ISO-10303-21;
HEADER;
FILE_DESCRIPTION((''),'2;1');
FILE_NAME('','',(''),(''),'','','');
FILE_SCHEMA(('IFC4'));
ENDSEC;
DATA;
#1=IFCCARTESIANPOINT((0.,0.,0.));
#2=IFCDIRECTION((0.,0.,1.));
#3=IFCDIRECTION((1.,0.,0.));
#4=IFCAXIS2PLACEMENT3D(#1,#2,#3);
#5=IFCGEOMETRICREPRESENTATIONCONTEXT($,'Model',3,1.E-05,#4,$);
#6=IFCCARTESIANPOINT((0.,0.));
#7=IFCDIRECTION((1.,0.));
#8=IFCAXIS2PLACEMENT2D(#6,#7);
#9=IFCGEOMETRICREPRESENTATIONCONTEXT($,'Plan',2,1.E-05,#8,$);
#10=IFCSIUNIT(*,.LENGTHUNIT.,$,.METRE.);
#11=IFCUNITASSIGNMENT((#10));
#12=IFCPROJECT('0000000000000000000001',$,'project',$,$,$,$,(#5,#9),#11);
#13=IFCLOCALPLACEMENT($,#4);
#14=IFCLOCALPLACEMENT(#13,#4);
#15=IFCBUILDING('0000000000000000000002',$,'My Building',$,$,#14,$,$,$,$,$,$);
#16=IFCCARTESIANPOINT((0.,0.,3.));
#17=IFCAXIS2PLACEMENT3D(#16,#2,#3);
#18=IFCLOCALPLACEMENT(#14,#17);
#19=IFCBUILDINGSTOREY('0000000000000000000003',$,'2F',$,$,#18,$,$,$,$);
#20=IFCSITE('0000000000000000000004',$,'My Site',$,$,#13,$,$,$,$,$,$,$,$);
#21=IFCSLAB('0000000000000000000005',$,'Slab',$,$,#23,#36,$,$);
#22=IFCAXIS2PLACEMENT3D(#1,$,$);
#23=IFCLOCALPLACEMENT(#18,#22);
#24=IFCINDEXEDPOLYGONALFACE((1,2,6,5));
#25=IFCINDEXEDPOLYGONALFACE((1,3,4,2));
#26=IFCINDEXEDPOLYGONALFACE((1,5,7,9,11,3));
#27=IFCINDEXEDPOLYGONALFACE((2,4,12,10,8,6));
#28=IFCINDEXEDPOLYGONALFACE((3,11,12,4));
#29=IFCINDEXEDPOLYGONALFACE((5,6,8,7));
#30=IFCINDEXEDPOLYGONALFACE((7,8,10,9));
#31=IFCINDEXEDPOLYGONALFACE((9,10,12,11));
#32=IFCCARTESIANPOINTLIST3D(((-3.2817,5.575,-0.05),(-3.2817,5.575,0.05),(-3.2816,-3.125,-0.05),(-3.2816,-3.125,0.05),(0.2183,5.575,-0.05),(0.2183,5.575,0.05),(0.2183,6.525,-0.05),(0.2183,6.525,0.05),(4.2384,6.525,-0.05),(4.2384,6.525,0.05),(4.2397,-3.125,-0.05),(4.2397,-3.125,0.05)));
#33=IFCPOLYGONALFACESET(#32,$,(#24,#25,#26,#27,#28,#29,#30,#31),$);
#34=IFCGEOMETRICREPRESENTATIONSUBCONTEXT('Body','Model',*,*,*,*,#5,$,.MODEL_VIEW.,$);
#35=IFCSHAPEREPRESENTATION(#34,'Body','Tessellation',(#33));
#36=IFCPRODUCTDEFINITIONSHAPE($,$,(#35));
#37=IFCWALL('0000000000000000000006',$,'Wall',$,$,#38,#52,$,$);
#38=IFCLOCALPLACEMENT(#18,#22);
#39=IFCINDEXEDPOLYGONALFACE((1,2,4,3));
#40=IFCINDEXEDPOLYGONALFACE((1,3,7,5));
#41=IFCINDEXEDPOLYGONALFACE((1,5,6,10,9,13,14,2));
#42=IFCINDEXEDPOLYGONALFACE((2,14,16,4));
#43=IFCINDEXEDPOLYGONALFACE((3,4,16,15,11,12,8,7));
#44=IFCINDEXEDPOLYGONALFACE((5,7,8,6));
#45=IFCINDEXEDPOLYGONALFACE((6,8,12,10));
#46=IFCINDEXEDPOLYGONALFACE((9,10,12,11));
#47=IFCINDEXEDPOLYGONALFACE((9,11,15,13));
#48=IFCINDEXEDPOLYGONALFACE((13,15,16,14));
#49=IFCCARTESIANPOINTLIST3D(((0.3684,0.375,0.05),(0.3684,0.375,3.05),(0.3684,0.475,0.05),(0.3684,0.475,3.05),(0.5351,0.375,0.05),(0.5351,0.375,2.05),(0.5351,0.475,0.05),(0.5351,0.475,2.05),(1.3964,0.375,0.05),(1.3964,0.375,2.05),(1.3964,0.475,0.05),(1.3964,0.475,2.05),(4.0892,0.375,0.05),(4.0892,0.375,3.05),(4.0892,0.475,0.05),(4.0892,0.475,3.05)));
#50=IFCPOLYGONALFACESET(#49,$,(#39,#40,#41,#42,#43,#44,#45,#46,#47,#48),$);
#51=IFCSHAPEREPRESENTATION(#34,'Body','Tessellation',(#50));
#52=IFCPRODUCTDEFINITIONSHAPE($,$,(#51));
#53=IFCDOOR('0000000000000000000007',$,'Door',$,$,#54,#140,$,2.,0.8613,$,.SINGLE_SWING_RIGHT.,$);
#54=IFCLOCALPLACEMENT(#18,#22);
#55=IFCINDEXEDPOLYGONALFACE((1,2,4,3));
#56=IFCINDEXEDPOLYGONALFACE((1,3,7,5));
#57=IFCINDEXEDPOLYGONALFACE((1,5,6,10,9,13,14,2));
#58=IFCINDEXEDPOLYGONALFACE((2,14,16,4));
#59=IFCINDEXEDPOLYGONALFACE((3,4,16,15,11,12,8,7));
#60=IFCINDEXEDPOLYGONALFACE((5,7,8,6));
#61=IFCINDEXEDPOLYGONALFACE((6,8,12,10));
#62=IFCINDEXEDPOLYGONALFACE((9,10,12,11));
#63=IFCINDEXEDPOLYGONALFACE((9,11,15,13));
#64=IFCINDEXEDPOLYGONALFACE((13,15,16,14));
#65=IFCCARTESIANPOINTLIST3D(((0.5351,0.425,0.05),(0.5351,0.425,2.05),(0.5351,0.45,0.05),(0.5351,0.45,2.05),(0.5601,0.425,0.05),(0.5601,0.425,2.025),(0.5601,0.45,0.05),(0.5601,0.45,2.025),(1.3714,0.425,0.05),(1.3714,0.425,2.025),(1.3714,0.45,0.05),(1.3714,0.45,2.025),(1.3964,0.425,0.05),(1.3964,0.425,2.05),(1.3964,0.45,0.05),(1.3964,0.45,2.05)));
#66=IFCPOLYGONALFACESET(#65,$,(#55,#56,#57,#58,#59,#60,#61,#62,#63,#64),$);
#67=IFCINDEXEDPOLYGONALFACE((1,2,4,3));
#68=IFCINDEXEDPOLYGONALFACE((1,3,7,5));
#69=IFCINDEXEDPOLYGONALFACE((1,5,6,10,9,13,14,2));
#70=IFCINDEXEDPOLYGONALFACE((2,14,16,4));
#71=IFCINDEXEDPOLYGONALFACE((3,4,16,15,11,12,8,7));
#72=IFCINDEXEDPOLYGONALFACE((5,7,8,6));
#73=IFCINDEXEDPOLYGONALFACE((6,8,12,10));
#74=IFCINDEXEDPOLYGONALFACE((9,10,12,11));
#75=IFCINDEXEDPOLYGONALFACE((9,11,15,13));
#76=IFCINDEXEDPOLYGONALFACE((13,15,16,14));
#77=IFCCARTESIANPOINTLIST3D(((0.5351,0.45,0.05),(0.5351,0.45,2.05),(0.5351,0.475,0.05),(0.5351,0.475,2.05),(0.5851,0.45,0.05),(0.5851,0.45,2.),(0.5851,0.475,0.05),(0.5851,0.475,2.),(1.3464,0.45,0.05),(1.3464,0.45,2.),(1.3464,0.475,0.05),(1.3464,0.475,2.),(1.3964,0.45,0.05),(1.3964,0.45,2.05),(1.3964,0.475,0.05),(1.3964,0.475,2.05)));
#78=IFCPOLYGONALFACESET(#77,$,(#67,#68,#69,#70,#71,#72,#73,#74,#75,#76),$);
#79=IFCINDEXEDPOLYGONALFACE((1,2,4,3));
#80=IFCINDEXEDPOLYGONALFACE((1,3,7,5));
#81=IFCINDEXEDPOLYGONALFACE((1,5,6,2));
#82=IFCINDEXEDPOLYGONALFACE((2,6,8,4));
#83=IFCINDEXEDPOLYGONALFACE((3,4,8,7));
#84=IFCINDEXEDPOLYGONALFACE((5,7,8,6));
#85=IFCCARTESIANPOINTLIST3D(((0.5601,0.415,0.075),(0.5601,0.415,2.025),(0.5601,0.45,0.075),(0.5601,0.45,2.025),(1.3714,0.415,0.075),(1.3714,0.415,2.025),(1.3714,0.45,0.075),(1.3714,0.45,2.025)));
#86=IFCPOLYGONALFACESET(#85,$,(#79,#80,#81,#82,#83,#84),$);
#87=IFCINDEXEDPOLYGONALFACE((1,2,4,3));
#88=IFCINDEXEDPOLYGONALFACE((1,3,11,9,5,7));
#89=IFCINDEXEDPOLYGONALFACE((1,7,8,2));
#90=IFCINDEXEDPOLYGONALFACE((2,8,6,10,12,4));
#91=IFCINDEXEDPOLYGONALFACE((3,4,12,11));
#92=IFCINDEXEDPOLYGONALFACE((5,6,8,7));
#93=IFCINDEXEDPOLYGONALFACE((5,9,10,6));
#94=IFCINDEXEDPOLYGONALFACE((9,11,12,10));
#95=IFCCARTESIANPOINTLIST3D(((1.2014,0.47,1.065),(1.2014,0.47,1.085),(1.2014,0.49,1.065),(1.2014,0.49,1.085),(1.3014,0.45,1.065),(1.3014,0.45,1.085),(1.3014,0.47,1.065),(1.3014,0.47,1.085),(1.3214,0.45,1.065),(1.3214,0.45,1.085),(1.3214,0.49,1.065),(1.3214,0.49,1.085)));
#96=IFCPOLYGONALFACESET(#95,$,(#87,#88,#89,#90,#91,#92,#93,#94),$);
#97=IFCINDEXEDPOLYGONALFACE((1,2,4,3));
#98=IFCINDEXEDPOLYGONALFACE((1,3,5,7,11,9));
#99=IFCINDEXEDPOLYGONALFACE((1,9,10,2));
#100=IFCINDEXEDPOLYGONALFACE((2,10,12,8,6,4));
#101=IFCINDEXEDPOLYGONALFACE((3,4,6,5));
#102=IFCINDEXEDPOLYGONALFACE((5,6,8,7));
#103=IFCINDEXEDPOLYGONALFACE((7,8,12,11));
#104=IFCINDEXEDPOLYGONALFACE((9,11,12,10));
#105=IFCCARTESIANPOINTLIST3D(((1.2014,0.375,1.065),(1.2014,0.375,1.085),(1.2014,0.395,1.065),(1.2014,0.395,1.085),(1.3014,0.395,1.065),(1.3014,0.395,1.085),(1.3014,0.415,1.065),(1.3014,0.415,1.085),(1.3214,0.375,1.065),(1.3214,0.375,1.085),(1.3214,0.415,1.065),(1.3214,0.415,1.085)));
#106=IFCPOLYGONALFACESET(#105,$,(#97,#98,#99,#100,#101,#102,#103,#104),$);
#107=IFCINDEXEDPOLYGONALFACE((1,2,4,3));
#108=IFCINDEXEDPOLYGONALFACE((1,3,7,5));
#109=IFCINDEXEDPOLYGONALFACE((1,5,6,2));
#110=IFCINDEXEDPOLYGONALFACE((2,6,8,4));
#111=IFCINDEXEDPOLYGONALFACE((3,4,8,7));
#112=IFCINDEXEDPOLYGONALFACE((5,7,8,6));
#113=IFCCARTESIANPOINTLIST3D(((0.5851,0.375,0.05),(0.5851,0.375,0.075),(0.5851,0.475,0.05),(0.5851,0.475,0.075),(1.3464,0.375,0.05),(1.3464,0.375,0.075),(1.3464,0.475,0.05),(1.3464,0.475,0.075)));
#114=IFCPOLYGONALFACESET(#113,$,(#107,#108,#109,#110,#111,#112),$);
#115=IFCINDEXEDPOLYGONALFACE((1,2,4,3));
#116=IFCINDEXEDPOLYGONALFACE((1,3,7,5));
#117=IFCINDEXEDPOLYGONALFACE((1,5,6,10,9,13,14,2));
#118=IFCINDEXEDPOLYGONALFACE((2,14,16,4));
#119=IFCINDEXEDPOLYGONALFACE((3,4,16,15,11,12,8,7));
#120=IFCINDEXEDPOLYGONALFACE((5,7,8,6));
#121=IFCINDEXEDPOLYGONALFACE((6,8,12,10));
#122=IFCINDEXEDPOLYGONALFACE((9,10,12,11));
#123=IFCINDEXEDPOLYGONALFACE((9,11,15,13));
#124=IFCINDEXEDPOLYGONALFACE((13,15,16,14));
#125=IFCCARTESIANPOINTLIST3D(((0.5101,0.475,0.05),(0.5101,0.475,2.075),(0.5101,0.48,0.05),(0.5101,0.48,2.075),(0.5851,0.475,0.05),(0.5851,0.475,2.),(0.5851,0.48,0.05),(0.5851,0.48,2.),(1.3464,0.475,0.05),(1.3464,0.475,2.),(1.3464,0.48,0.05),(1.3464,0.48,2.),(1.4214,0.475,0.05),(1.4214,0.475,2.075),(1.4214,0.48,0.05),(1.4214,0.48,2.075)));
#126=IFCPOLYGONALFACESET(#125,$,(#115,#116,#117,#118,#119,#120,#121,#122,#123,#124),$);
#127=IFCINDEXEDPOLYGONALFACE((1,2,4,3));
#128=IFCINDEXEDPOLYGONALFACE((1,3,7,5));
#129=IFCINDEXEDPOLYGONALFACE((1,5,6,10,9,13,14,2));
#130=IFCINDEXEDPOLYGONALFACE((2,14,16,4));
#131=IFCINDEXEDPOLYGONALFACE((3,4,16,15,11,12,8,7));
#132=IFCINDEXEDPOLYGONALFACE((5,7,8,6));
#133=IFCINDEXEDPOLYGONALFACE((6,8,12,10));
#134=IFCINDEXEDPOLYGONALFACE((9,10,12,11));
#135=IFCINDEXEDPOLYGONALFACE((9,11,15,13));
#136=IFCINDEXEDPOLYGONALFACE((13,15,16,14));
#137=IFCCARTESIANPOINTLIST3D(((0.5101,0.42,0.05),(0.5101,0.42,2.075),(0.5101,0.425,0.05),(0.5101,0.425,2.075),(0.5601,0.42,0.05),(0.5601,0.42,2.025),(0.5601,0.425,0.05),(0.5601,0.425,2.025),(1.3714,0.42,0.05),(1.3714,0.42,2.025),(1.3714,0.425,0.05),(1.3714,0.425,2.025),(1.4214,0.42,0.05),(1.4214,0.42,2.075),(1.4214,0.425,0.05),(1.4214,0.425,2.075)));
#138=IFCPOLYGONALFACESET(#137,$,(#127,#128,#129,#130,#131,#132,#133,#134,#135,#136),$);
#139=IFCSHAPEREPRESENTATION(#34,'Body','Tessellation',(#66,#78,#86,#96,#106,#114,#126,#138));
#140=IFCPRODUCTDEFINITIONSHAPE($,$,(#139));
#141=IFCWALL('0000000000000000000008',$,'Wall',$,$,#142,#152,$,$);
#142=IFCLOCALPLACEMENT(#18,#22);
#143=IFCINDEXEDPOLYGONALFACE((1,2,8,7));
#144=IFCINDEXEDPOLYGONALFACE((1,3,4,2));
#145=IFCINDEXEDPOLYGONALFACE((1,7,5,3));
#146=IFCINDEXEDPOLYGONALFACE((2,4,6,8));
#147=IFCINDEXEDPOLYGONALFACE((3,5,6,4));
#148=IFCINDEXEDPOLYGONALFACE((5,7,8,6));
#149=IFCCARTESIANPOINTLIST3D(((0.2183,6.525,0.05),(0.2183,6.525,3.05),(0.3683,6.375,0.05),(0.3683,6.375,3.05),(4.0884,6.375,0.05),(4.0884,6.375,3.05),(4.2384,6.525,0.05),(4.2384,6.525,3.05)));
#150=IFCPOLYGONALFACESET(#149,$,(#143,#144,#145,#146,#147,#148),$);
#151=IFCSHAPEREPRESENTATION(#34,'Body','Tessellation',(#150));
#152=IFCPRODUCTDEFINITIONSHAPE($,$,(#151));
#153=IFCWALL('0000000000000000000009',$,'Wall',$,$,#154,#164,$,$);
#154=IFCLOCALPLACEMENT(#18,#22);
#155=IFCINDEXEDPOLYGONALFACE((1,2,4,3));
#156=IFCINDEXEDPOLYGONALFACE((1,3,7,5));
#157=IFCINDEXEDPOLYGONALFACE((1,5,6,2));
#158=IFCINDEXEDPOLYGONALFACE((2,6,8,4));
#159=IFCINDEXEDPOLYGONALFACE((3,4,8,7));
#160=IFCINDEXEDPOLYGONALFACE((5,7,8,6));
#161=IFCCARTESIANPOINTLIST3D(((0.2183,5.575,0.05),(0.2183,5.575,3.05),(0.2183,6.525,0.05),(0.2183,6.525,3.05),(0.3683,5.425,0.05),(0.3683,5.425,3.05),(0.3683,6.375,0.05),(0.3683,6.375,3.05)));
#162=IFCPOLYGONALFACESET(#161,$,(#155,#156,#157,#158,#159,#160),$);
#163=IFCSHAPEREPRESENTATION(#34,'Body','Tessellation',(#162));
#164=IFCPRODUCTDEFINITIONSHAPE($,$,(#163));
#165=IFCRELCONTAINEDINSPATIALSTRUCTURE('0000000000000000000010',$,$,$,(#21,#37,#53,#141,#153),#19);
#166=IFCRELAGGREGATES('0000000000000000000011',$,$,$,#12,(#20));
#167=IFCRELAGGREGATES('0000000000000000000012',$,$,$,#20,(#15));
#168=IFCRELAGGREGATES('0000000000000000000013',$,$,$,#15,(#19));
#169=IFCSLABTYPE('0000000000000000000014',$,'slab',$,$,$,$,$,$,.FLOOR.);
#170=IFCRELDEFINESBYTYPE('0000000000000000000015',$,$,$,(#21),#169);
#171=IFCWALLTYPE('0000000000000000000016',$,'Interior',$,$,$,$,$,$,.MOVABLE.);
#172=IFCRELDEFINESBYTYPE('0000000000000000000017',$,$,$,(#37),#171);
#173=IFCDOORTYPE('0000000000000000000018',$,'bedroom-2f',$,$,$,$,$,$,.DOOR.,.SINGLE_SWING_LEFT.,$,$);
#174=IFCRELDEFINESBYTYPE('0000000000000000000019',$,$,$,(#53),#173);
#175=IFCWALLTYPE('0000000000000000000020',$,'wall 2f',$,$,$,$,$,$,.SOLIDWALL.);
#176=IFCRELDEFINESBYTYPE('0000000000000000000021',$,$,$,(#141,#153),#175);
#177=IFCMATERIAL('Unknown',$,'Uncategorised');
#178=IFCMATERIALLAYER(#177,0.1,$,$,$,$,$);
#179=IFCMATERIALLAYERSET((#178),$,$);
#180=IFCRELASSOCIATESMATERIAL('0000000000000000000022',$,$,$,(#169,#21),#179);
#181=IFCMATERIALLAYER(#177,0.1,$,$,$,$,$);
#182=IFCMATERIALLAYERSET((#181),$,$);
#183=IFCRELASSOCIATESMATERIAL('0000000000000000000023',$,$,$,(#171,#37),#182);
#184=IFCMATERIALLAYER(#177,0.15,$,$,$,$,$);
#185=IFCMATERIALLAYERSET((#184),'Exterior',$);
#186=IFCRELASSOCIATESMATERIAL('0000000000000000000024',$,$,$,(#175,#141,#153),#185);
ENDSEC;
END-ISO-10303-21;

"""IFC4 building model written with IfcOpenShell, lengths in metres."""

from ifc_helpers import new_model, entity, si_unit, frame, origin_with_axes, origin_2d_with_axis, place, context, subcontext, project, spatial, line, indexed_curve, outline, extrude, shape, source, transform, mapped, material, layer, layer_set, layer_usage, type_object, type_shapes, element, fill, save


model = new_model("IFC4")

# Units and contexts
model_context = context("Model", 3, precision=1e-05, world=origin_with_axes())
plan_context = context("Plan", 2, precision=1e-05, world=origin_2d_with_axis())
body_context_1 = subcontext(model_context, "Body", "Model", "MODEL_VIEW")
body_context_2 = subcontext(plan_context, "Body", "Plan", "PLAN_VIEW")
ifc_project = project(units=[si_unit("LENGTHUNIT", "METRE")], contexts=[model_context, plan_context])

# Site, building, storey
site_placement = place(None, origin_with_axes())
site = spatial("IfcSite", under=ifc_project, at=site_placement, Name="My Site")
building_placement = place(site_placement, origin_with_axes())
building = spatial("IfcBuilding", under=site, at=building_placement, Name="My Building")
storey_placement = place(building_placement, frame((0.0, 0.0, 3.0), z_axis=(0.0, 0.0, 1.0), x_axis=(1.0, 0.0, 0.0)))
storey = spatial("IfcBuildingStorey", under=building, at=storey_placement, Name="2F")

# Slab
ifc_material = material(Name="Unknown", Category="Uncategorised")
ifc_layer_1 = layer(ifc_material, 0.1)
ifc_layer_set_1 = layer_set([ifc_layer_1])
ifc_layer_usage_1 = layer_usage(ifc_layer_set_1, "AXIS3", "POSITIVE", -0.1)
slab_type = type_object("IfcSlabType", Name="slab", PredefinedType="FLOOR", material=ifc_layer_set_1)
slab_placement = place(storey_placement, frame((4.2384, 6.525, 0.05), z_axis=(0.0, 0.0, 1.0), x_axis=(1.0, 0.0, 0.0)))
element("IfcSlab", 1, at=slab_placement, inside=storey, type_object=slab_type, material=ifc_layer_usage_1, Name="Slab", context=body_context_1, shape_type="SweptSolid", body=[
    extrude(outline(indexed_curve([(0.0, 0.0), (-4.02, 0.0), (-4.02, -0.95), (-7.52, -0.95), (-7.52, -9.65), (0.0014, -9.65), (0.0, 0.0)])), frame((0.0, 0.0, -0.1), z_axis=(0.0, 0.0, 1.0), x_axis=(1.0, 0.0, 0.0)), (0.0, 0.0, 1.0), 0.1),
])

# Shared definitions
ifc_layer_2 = layer(ifc_material, 0.1)
ifc_layer_set_2 = layer_set([ifc_layer_2])
wall_type_1 = type_object("IfcWallType", Name="Interior", PredefinedType="MOVABLE", material=ifc_layer_set_2)
shared_shape_1 = source(origin_with_axes(), body_context_1, "Body", "SweptSolid", [
    extrude(outline(indexed_curve([(0.0, 0.0), (0.8613, 0.0), (0.8613, 2.0), (0.0, 2.0)], segments=[line(1, 2, 3, 4, 1)])), frame((0.0, -0.6, 0.0), z_axis=(0.0, -1.0, 0.0), x_axis=(1.0, 0.0, 0.0)), (0.0, 0.0, -1.0), 1.2),
])
door_type_1 = type_object("IfcDoorType", Name="bedroom-2f", OperationType="SINGLE_SWING_LEFT", PredefinedType="DOOR")
shared_shape_2 = source(origin_with_axes(), body_context_1, "Body", "SweptSolid", [
    extrude(outline(indexed_curve([(0.0, 0.0), (0.0, 2.0), (0.8613, 2.0), (0.8613, 0.0), (0.8363, 0.0), (0.8363, 1.975), (0.025, 1.975), (0.025, 0.0)], segments=[line(1, 2, 3, 4, 5, 6, 7, 8, 1)])), frame((0.0, 0.025, 0.0), z_axis=(0.0, -1.0, 0.0), x_axis=(1.0, 0.0, 0.0)), (0.0, 0.0, -1.0), 0.025),
    extrude(outline(indexed_curve([(0.0, 0.0), (0.0, 2.0), (0.8613, 2.0), (0.8613, 0.0), (0.8113, 0.0), (0.8113, 1.95), (0.05, 1.95), (0.05, 0.0)], segments=[line(1, 2, 3, 4, 5, 6, 7, 8, 1)])), frame((0.0, 0.0, 0.0), z_axis=(0.0, -1.0, 0.0), x_axis=(1.0, 0.0, 0.0)), (0.0, 0.0, -1.0), 0.025),
    extrude(outline(indexed_curve([(0.0, 0.0), (0.8113, 0.0), (0.8113, 0.035), (0.0, 0.035)], segments=[line(1, 2, 3, 4, 1)])), frame((0.025, 0.025, 0.025), z_axis=(0.0, 0.0, 1.0), x_axis=(1.0, 0.0, 0.0)), (0.0, 0.0, 1.0), 1.95),
    extrude(outline(indexed_curve([(0.0, 0.0), (0.0, -0.04), (0.12, -0.04), (0.12, -0.02), (0.02, -0.02), (0.02, 0.0)], segments=[line(1, 2, 3, 4, 5, 6, 1)])), frame((0.075, 0.025, 1.015), z_axis=(0.0, 0.0, 1.0), x_axis=(1.0, 0.0, 0.0)), (0.0, 0.0, 1.0), 0.02),
    extrude(outline(indexed_curve([(0.0, 0.0), (0.0, 0.04), (0.12, 0.04), (0.12, 0.02), (0.02, 0.02), (0.02, 0.0)], segments=[line(1, 2, 3, 4, 5, 6, 1)])), frame((0.075, 0.06, 1.015), z_axis=(0.0, 0.0, 1.0), x_axis=(1.0, 0.0, 0.0)), (0.0, 0.0, 1.0), 0.02),
    extrude(outline(indexed_curve([(0.0, 0.0), (0.7613, 0.0), (0.7613, 0.1), (0.0, 0.1)], segments=[line(1, 2, 3, 4, 1)])), frame((0.05, 0.0, 0.0), z_axis=(0.0, 0.0, 1.0), x_axis=(1.0, 0.0, 0.0)), (0.0, 0.0, 1.0), 0.025),
    extrude(outline(indexed_curve([(0.0, 0.0), (0.0, 2.025), (0.9113, 2.025), (0.9113, 0.0), (0.8363, 0.0), (0.8363, 1.95), (0.075, 1.95), (0.075, 0.0)], segments=[line(1, 2, 3, 4, 5, 6, 7, 8, 1)])), frame((-0.025, -0.005, 0.0), z_axis=(0.0, -1.0, 0.0), x_axis=(1.0, 0.0, 0.0)), (0.0, 0.0, -1.0), 0.005),
    extrude(outline(indexed_curve([(0.0, 0.0), (0.0, 2.025), (0.9113, 2.025), (0.9113, 0.0), (0.8613, 0.0), (0.8613, 1.975), (0.05, 1.975), (0.05, 0.0)], segments=[line(1, 2, 3, 4, 5, 6, 7, 8, 1)])), frame((-0.025, 0.05, 0.0), z_axis=(0.0, -1.0, 0.0), x_axis=(1.0, 0.0, 0.0)), (0.0, 0.0, -1.0), 0.005),
])
shared_shape_3 = source(origin_with_axes(), body_context_2, "Body", "Curve2D", [
    entity("IfcIndexedPolyCurve", entity("IfcCartesianPointList2D", [[0.0, 0.0], [0.0, 0.05], [0.025, 0.05], [0.025, 0.025], [0.05, 0.025], [0.05, 0.0]]), [entity("IfcLineIndex", [1, 2, 3, 4, 5, 6, 1])]),
    entity("IfcIndexedPolyCurve", entity("IfcCartesianPointList2D", [[0.8613, 0.0], [0.8613, 0.05], [0.8363, 0.05], [0.8363, 0.025], [0.8113, 0.025], [0.8113, 0.0]]), [entity("IfcLineIndex", [1, 2, 3, 4, 5, 6, 1])]),
    entity("IfcTrimmedCurve", entity("IfcEllipse", entity("IfcAxis2Placement2D", entity("IfcCartesianPoint", [0.8013, 0.05]), entity("IfcDirection", [1.0, 0.0])), 0.7763, 0.8113), [entity("IfcCartesianPoint", [0.8013, 0.8613])], [entity("IfcCartesianPoint", [0.025, 0.05])], True, "CARTESIAN"),
    entity("IfcIndexedPolyCurve", entity("IfcCartesianPointList2D", [[0.8363, 0.05], [0.8013, 0.05], [0.8013, 0.8613], [0.8363, 0.8613]]), [entity("IfcLineIndex", [1, 2, 3, 4, 1])]),
])
type_shapes(door_type_1, [shared_shape_2, shared_shape_3])

# Wall, opening, door
ifc_layer_usage_2 = layer_usage(ifc_layer_set_2, "AXIS2", "POSITIVE", 0.0)
wall_1_placement = place(storey_placement, frame((0.3684, 0.375, 0.05), z_axis=(0.0, 0.0, 1.0), x_axis=(1.0, 0.0, 0.0)))
wall_1 = element("IfcWall", 2, at=wall_1_placement, inside=storey, type_object=wall_type_1, material=ifc_layer_usage_2, Name="Wall", context=body_context_1, shape_type="SweptSolid", body=[
    extrude(outline(indexed_curve([(0.0, 0.0), (0.0, 0.1), (3.7209, 0.1), (3.7209, 0.0)], segments=[line(1, 2, 3, 4, 1)])), origin_with_axes(), (0.0, 0.0, 1.0), 3.0),
])
opening_1_placement = place(wall_1_placement, frame((1.028, 0.1, 0.0), z_axis=(0.0, 0.0, 1.0), x_axis=(-1.0, 0.0, 0.0)))
opening_1 = element("IfcOpeningElement", 3, at=opening_1_placement, cuts=wall_1, PredefinedType="OPENING", context=body_context_1, shape_type="MappedRepresentation", body=[
    mapped(shared_shape_1, transform((0.0, 0.0, 0.0), x_axis=(1.0, 0.0, 0.0), y_axis=(0.0, 1.0, 0.0), z_axis=(0.0, 0.0, 1.0), scale=1.0)),
])
door_1_placement = place(opening_1_placement, origin_with_axes())
door_1 = element("IfcDoor", 4, at=door_1_placement, inside=storey, type_object=door_type_1, Name="Door", OperationType="SINGLE_SWING_RIGHT", OverallHeight=2.0, OverallWidth=0.8613, shapes=[
    shape(body_context_1, "Body", "MappedRepresentation", [mapped(shared_shape_2, transform((0.0, 0.0, 0.0), x_axis=(1.0, 0.0, 0.0), y_axis=(0.0, 1.0, 0.0), z_axis=(0.0, 0.0, 1.0), scale=1.0))]),
    shape(body_context_2, "Body", "MappedRepresentation", [mapped(shared_shape_3, transform((0.0, 0.0, 0.0), x_axis=(1.0, 0.0, 0.0), y_axis=(0.0, 1.0, 0.0), z_axis=(0.0, 0.0, 1.0), scale=1.0))]),
])
fill(opening_1, door_1)

# Walls
ifc_layer_3 = layer(ifc_material, 0.15)
ifc_layer_set_3 = layer_set([ifc_layer_3], Name="Exterior")
ifc_layer_usage_3 = layer_usage(ifc_layer_set_3, "AXIS2", "POSITIVE", 0.0)
wall_type_2 = type_object("IfcWallType", Name="wall 2f", PredefinedType="SOLIDWALL", material=ifc_layer_set_3)
wall_2_placement = place(storey_placement, frame((4.2384, 6.525, 0.05), z_axis=(0.0, 0.0, 1.0), x_axis=(-1.0, 0.0, 0.0)))
element("IfcWall", 5, at=wall_2_placement, inside=storey, type_object=wall_type_2, material=ifc_layer_usage_3, Name="Wall", context=body_context_1, shape_type="SweptSolid", body=[
    extrude(outline(indexed_curve([(0.0, 0.0), (0.15, 0.15), (3.87, 0.15), (4.02, 0.0)], segments=[line(1, 2, 3, 4, 1)])), origin_with_axes(), (0.0, 0.0, 1.0), 3.0),
])
ifc_layer_usage_4 = layer_usage(ifc_layer_set_3, "AXIS2", "POSITIVE", 0.0)
wall_3_placement = place(storey_placement, frame((0.2183, 6.525, 0.05), z_axis=(0.0, 0.0, 1.0), x_axis=(0.0, -1.0, 0.0)))
element("IfcWall", 6, at=wall_3_placement, inside=storey, type_object=wall_type_2, material=ifc_layer_usage_4, Name="Wall", context=body_context_1, shape_type="SweptSolid", body=[
    extrude(outline(indexed_curve([(0.0, 0.0), (0.15, 0.15), (1.1, 0.15), (0.95, 0.0)], segments=[line(1, 2, 3, 4, 1)])), origin_with_axes(), (0.0, 0.0, 1.0), 3.0),
])

save(model, "model.ifc")
